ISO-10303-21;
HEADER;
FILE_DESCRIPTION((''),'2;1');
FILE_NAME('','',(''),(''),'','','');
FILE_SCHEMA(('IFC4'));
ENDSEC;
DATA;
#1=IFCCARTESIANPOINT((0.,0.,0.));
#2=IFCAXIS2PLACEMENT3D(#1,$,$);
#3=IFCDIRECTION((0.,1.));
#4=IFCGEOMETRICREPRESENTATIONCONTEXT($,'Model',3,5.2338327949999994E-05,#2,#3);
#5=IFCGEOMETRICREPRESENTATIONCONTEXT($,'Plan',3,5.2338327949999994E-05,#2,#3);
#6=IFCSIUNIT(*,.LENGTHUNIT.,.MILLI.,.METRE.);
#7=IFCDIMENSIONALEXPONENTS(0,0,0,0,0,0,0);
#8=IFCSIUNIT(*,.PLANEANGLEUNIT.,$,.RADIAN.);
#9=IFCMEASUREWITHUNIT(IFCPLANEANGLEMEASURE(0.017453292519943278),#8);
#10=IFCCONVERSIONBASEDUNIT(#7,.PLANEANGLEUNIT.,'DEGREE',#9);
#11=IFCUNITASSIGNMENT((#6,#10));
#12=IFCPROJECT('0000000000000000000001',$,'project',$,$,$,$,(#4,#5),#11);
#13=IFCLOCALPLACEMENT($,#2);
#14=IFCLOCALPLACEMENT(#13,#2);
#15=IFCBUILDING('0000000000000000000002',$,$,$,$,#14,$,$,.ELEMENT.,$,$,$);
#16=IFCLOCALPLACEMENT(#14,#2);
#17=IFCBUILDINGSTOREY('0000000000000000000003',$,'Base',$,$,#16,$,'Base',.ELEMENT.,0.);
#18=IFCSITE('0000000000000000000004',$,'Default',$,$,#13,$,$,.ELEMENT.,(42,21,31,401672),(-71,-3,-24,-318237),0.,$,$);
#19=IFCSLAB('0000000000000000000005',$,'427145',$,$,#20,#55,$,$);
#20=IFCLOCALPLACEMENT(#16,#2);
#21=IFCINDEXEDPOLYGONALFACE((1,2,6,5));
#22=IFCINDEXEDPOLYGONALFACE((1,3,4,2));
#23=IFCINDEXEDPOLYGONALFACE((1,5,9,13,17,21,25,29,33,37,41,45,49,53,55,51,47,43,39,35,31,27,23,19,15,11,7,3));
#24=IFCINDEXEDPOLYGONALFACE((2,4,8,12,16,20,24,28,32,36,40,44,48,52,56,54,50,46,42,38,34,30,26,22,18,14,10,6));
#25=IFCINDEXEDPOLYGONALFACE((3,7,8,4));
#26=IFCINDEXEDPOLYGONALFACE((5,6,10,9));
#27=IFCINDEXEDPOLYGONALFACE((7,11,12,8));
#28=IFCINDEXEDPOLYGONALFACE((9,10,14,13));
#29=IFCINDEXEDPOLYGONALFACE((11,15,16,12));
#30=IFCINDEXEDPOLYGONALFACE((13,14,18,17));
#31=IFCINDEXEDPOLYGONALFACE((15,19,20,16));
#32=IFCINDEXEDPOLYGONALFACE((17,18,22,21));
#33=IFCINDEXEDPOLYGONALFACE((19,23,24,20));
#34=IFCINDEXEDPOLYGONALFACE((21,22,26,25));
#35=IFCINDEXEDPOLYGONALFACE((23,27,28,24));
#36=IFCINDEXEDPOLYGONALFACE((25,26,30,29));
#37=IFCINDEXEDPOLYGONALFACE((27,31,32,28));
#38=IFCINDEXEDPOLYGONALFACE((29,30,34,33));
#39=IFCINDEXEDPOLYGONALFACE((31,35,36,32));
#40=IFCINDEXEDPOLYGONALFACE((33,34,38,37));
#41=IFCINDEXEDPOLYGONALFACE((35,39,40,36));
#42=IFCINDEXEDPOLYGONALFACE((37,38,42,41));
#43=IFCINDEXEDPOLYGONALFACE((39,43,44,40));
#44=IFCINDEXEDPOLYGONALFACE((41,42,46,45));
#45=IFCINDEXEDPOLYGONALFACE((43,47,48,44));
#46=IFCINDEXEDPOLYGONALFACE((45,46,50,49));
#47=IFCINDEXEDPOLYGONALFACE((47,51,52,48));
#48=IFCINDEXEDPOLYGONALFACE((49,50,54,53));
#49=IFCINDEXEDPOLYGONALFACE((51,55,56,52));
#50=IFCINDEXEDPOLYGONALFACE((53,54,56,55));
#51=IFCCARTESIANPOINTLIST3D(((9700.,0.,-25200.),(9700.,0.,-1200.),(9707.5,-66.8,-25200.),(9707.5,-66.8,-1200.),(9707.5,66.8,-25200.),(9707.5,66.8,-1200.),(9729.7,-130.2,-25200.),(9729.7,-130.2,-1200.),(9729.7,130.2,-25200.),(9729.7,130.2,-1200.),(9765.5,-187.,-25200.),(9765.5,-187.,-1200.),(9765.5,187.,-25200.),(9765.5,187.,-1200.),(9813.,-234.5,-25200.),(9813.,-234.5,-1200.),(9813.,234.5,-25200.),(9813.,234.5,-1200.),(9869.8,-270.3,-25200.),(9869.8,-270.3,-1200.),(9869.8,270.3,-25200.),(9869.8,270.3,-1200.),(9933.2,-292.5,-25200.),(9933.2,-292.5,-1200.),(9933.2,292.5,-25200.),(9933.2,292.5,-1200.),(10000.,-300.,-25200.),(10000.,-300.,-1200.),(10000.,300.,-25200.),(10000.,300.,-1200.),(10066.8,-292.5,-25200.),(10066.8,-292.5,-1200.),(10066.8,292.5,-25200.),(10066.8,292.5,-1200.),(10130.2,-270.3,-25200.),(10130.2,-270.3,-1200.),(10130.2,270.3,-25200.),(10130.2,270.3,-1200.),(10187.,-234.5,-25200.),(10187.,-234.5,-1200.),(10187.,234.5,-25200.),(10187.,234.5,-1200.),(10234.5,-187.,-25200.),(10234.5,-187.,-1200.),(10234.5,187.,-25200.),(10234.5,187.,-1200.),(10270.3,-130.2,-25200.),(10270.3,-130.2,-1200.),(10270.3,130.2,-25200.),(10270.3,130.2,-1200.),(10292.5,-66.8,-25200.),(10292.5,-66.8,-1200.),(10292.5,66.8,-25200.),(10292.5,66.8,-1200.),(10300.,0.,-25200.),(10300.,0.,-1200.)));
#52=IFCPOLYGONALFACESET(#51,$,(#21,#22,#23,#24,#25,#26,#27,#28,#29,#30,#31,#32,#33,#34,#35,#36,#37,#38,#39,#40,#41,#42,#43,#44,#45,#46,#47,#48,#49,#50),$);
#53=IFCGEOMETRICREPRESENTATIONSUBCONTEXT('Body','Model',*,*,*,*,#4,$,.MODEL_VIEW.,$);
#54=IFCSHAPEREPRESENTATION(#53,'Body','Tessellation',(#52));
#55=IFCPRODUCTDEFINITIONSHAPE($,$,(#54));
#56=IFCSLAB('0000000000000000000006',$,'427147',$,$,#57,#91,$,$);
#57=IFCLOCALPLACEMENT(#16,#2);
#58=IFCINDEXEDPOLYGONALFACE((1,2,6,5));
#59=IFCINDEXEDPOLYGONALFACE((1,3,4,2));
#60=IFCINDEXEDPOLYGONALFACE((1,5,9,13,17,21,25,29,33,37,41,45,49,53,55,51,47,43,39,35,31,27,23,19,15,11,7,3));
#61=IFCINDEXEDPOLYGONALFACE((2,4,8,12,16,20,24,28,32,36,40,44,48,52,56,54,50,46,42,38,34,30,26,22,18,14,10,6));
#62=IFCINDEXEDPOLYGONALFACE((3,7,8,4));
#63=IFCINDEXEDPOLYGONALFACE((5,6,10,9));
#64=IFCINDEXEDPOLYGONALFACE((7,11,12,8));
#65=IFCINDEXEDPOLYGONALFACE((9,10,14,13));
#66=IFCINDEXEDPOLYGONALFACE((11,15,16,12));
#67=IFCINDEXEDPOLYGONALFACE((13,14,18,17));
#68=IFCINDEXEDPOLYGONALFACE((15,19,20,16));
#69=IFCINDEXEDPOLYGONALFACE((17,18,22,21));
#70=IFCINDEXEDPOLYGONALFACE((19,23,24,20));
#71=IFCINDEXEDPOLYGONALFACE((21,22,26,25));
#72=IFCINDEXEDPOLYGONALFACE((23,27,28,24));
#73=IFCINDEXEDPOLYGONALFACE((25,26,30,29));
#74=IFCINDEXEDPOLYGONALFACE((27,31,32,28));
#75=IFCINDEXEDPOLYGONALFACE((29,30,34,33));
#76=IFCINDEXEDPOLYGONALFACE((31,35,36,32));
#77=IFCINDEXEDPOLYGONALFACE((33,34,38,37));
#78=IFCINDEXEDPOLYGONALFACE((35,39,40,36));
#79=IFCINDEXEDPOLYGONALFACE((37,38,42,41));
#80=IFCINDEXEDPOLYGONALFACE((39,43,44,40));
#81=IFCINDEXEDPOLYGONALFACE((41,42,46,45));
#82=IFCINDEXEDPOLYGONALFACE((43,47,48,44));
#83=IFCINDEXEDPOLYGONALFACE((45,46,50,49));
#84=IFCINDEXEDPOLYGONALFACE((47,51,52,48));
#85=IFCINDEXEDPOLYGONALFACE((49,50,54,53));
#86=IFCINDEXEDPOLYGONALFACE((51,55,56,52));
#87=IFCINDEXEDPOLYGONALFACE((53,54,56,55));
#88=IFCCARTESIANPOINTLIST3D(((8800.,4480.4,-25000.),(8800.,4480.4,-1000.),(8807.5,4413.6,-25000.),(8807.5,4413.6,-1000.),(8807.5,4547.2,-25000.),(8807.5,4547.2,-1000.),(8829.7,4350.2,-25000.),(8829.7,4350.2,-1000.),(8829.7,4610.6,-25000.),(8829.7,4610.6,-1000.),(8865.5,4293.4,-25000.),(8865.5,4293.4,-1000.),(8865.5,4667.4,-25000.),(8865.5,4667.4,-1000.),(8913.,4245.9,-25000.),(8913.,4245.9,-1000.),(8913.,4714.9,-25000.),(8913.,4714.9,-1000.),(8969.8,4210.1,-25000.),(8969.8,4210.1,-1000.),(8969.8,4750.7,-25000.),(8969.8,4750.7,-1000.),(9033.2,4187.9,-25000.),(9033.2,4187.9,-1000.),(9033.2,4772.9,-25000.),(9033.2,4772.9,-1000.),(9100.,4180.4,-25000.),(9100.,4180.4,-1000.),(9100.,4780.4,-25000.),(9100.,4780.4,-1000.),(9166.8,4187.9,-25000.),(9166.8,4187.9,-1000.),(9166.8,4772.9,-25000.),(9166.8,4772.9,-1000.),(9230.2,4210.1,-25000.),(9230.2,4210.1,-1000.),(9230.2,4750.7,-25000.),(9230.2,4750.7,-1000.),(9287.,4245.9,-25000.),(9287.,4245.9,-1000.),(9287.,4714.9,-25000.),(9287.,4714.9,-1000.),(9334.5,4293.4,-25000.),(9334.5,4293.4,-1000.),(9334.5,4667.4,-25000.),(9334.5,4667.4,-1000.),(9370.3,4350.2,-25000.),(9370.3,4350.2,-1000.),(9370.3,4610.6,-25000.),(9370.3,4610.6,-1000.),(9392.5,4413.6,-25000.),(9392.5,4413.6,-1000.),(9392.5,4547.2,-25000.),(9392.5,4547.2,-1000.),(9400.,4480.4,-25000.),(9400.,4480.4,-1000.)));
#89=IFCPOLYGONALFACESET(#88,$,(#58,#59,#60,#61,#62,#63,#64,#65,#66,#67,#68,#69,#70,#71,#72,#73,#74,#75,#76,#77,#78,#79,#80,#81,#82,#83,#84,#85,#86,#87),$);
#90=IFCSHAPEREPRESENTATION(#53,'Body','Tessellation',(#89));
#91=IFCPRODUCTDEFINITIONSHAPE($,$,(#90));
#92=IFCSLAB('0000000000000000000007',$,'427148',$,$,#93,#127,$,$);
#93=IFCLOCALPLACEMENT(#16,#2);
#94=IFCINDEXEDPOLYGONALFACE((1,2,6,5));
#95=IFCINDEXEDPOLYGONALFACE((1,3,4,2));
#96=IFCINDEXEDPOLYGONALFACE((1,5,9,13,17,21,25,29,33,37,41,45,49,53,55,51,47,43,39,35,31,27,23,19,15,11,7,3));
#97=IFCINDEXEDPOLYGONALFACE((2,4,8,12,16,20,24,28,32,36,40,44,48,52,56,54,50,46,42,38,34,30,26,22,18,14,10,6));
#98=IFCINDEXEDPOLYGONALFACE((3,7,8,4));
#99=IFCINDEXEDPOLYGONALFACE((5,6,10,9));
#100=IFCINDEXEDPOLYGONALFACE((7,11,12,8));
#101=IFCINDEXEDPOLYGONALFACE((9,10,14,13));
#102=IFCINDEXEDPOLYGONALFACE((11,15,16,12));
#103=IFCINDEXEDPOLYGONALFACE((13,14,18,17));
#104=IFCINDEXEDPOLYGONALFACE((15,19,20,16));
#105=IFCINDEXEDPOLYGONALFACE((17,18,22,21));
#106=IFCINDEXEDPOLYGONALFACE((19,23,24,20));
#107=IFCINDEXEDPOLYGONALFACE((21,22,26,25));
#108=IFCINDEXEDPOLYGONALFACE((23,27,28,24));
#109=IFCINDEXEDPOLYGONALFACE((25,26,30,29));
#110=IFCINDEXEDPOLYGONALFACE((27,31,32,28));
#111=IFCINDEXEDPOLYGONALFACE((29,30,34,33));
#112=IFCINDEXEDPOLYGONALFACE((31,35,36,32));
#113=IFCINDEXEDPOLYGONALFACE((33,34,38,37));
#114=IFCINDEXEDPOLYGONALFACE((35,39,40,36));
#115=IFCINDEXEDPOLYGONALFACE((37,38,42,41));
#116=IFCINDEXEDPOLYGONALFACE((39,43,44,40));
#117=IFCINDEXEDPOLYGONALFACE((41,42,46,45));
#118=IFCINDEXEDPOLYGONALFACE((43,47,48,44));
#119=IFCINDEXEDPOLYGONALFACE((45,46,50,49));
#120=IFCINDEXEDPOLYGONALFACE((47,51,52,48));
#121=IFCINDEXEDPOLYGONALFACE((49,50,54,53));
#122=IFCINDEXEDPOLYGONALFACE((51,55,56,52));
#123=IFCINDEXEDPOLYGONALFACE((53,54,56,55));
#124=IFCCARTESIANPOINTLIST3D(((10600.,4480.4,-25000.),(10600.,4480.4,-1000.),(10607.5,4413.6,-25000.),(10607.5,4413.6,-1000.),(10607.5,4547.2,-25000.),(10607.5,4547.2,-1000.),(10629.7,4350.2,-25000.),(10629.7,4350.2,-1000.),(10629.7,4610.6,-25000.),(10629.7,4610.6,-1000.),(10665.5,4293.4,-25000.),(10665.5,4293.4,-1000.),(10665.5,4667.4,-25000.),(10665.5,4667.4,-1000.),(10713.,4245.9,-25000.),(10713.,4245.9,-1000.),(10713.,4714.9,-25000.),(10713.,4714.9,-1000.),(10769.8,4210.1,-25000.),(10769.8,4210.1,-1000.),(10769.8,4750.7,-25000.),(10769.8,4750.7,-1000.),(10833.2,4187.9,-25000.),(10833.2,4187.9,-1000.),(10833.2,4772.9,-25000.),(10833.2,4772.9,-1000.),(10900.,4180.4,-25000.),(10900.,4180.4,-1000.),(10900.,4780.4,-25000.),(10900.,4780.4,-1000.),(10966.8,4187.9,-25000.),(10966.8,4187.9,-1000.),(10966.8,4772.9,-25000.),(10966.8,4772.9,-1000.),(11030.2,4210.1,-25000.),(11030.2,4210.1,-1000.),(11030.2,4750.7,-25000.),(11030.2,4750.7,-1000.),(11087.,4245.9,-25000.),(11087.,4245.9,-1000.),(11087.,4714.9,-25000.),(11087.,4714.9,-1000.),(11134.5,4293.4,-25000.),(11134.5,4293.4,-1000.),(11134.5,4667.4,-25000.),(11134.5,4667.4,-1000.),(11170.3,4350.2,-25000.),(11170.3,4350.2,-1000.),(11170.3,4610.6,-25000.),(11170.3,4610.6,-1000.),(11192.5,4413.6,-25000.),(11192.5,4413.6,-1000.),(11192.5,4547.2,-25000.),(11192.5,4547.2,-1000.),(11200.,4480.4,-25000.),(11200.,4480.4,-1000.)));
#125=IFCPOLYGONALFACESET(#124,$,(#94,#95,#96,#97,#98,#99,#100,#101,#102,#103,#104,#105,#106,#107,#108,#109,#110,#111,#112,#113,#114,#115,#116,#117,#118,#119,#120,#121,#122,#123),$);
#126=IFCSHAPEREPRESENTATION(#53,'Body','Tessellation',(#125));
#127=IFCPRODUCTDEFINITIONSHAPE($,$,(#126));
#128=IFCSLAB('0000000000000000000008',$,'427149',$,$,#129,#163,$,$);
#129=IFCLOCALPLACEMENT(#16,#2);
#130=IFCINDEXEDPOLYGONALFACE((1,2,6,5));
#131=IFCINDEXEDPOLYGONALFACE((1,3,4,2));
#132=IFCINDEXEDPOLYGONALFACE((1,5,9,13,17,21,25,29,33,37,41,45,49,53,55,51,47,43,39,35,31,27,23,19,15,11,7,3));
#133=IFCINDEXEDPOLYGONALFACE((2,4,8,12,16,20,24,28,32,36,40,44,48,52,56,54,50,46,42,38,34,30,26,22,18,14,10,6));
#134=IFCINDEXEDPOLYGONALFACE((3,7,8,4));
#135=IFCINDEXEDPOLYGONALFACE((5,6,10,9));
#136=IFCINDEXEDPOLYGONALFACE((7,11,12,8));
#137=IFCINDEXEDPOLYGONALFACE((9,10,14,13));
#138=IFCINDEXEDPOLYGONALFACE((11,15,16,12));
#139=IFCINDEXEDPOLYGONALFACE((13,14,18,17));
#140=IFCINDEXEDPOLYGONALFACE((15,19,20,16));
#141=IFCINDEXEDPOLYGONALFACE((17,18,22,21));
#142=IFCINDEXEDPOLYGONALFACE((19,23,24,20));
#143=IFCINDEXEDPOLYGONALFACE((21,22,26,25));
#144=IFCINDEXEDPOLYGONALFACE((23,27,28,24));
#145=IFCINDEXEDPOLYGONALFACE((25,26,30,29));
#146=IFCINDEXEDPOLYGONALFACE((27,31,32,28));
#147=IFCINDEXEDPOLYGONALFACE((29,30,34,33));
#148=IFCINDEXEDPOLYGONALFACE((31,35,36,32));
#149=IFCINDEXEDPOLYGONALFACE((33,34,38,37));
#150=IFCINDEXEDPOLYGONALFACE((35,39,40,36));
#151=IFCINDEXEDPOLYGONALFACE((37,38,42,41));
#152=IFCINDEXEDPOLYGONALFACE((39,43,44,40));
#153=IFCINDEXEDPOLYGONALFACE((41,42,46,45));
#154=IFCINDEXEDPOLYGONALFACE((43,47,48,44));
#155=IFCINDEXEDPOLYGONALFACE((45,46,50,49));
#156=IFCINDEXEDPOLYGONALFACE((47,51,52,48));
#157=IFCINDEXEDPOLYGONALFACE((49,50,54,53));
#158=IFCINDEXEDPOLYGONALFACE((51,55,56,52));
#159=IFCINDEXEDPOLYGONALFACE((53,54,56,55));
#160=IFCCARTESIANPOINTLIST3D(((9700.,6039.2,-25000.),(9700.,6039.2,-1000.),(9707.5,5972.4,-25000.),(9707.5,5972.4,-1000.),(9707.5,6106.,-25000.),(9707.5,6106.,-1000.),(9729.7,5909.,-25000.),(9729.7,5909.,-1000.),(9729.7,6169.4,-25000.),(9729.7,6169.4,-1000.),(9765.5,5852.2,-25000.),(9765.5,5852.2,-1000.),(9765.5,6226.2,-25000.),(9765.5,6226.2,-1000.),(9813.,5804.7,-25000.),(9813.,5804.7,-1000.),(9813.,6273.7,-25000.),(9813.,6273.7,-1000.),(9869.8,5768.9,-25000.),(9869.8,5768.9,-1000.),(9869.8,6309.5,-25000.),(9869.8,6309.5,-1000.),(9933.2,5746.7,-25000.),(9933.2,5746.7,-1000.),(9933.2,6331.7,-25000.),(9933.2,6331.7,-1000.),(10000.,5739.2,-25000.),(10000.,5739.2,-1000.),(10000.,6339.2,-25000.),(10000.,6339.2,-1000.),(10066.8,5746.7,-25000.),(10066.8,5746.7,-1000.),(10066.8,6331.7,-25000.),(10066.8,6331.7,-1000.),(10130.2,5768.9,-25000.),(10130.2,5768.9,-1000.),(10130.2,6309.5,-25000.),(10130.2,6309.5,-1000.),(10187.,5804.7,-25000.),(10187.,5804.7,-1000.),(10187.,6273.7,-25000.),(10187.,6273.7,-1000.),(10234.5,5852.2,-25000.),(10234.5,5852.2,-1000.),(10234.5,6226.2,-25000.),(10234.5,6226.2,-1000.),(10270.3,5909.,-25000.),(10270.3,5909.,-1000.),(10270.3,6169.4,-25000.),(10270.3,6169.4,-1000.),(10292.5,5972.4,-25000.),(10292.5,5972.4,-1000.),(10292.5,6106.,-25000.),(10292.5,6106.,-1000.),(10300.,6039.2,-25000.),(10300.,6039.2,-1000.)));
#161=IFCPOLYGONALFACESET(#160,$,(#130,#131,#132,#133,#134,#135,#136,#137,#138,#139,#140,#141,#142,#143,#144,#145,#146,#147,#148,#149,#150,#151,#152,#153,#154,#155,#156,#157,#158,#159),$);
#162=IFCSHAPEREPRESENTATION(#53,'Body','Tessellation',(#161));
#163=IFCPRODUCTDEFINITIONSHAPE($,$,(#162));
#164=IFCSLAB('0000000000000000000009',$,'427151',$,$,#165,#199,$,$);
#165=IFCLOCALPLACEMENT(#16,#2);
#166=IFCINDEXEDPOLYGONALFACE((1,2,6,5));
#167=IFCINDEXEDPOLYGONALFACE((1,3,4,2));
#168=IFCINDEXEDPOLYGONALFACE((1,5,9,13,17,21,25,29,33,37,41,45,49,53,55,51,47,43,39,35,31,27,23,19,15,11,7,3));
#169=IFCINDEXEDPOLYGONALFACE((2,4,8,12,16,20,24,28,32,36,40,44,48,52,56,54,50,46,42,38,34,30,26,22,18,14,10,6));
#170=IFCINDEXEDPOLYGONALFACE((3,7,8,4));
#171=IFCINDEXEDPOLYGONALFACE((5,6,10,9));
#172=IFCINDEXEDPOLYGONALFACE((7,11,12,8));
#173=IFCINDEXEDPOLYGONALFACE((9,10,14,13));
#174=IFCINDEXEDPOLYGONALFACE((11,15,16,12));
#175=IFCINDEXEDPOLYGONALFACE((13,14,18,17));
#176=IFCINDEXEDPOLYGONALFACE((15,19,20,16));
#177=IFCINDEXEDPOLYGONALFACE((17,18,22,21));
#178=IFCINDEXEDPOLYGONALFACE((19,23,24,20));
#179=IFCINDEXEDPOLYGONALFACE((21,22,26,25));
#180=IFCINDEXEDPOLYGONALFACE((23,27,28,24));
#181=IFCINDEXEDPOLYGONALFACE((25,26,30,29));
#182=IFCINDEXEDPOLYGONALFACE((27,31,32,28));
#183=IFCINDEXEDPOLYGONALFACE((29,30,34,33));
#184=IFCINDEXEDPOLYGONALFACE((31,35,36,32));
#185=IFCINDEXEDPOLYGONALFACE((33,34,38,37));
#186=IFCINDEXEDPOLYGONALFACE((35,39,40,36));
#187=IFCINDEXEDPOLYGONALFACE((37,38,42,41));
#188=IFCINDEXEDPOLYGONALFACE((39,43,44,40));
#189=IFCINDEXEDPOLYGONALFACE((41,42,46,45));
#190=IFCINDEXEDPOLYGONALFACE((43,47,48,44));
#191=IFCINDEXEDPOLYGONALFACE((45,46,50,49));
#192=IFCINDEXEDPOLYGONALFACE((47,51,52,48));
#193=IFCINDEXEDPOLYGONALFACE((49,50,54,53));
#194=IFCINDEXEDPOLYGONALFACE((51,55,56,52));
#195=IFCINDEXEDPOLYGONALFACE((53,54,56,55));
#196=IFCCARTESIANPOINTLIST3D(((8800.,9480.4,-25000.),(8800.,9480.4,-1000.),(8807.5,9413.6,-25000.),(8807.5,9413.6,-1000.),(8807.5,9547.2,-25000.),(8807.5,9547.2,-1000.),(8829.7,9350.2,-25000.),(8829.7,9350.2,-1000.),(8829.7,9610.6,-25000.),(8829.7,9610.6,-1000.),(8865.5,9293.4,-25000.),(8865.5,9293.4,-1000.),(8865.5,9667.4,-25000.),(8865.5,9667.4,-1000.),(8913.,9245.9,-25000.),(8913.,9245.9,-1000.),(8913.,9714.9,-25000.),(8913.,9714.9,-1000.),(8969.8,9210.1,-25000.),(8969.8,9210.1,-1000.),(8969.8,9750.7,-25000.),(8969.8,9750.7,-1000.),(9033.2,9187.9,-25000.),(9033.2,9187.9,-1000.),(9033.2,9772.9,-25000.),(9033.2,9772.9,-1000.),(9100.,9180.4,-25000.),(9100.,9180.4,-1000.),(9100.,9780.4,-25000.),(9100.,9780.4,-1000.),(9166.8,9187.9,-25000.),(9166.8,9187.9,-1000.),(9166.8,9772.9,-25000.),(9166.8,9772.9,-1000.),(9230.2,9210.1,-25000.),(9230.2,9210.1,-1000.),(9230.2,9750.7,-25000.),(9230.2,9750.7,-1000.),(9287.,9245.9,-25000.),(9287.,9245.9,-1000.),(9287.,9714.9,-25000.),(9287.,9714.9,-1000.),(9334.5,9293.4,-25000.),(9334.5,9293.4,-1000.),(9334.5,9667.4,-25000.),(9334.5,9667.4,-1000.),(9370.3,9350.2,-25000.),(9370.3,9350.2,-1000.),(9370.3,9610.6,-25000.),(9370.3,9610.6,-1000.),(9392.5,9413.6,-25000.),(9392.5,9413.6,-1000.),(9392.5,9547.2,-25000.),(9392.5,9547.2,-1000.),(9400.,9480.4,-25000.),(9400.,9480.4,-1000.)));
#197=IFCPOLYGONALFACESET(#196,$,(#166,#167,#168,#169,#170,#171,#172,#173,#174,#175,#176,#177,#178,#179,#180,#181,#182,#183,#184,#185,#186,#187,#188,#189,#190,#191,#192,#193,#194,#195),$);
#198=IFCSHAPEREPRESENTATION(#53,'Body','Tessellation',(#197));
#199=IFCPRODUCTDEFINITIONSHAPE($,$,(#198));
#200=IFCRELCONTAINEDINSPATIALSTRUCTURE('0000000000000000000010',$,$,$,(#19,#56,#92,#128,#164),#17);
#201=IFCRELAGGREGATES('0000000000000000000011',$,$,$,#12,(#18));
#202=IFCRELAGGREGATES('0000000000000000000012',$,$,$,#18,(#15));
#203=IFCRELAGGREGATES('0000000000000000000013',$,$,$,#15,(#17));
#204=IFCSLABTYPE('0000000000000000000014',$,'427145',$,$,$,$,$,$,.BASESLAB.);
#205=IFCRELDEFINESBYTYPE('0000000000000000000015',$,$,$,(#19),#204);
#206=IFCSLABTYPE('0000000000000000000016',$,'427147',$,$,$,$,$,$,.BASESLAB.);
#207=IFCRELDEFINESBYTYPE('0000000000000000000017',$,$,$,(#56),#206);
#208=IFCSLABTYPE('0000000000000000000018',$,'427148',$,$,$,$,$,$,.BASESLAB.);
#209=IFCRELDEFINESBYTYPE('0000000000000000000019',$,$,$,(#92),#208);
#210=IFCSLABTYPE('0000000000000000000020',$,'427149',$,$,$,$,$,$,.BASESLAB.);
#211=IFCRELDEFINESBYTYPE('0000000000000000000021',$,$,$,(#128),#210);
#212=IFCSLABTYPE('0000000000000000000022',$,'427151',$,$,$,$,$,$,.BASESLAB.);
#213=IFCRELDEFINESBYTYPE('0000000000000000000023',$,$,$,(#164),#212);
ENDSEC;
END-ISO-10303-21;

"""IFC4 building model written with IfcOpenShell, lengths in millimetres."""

from ifc_helpers import new_model, entity, si_unit, converted_unit, direction, frame, origin, place, context, subcontext, project, spatial, arc, indexed_curve, outline, extrude, type_object, element, save


model = new_model("IFC4")

# Units and contexts
model_context = context("Model", 3, precision=5.2338327949999994e-05, world=origin(), true_north=direction((0.0, 1.0)))
plan_context = context("Plan", 3, precision=5.2338327949999994e-05, world=origin(), true_north=direction((0.0, 1.0)))
body_context = subcontext(model_context, "Body", "Model", "MODEL_VIEW")
ifc_project = project(units=[si_unit("LENGTHUNIT", "METRE", prefix="MILLI"), converted_unit("PLANEANGLEUNIT", "DEGREE", entity("IfcPlaneAngleMeasure", 0.017453292519943278), si_unit("PLANEANGLEUNIT", "RADIAN"), dimensions=[0, 0, 0, 0, 0, 0, 0])], contexts=[model_context, plan_context])

# Site, building, storey
site_placement = place(None, origin())
site = spatial("IfcSite", under=ifc_project, at=site_placement, Name="Default", CompositionType="ELEMENT", RefLatitude=(42, 21, 31, 401672), RefLongitude=(-71, -3, -24, -318237), RefElevation=0.0)
building_placement = place(site_placement, origin())
building = spatial("IfcBuilding", under=site, at=building_placement, CompositionType="ELEMENT")
storey_placement = place(building_placement, origin())
storey = spatial("IfcBuildingStorey", under=building, at=storey_placement, Name="Base", LongName="Base", CompositionType="ELEMENT", Elevation=0.0)

# Slabs
slab_type_1 = type_object("IfcSlabType", Name="427145", PredefinedType="BASESLAB")
slab_1_placement = place(storey_placement, origin())
element("IfcSlab", 1, at=slab_1_placement, inside=storey, type_object=slab_type_1, Name="427145", context=body_context, shape_type="SweptSolid", body=[
    extrude(outline(indexed_curve([(300.0, 0.0), (0.0, 300.0), (-300.0, 0.0), (0.0, -300.0)], segments=[arc(1, 2, 3), arc(3, 4, 1)], self_intersect=False)), frame((10000.0, 0.0, -25200.0)), (0.0, 0.0, 1.0), 24000.0),
])
slab_type_2 = type_object("IfcSlabType", Name="427147", PredefinedType="BASESLAB")
slab_2_placement = place(storey_placement, origin())
element("IfcSlab", 2, at=slab_2_placement, inside=storey, type_object=slab_type_2, Name="427147", context=body_context, shape_type="SweptSolid", body=[
    extrude(outline(indexed_curve([(300.0, 0.0), (0.0, 300.0), (-300.0, 0.0), (0.0, -300.0)], segments=[arc(1, 2, 3), arc(3, 4, 1)], self_intersect=False)), frame((9100.0, 4480.4, -25000.0)), (0.0, 0.0, 1.0), 24000.0),
])
slab_type_3 = type_object("IfcSlabType", Name="427148", PredefinedType="BASESLAB")
slab_3_placement = place(storey_placement, origin())
element("IfcSlab", 3, at=slab_3_placement, inside=storey, type_object=slab_type_3, Name="427148", context=body_context, shape_type="SweptSolid", body=[
    extrude(outline(indexed_curve([(300.0, 0.0), (0.0, 300.0), (-300.0, 0.0), (0.0, -300.0)], segments=[arc(1, 2, 3), arc(3, 4, 1)], self_intersect=False)), frame((10900.0, 4480.4, -25000.0)), (0.0, 0.0, 1.0), 24000.0),
])
slab_type_4 = type_object("IfcSlabType", Name="427149", PredefinedType="BASESLAB")
slab_4_placement = place(storey_placement, origin())
element("IfcSlab", 4, at=slab_4_placement, inside=storey, type_object=slab_type_4, Name="427149", context=body_context, shape_type="SweptSolid", body=[
    extrude(outline(indexed_curve([(300.0, 0.0), (0.0, 300.0), (-300.0, 0.0), (0.0, -300.0)], segments=[arc(1, 2, 3), arc(3, 4, 1)], self_intersect=False)), frame((10000.0, 6039.2, -25000.0)), (0.0, 0.0, 1.0), 24000.0),
])
slab_type_5 = type_object("IfcSlabType", Name="427151", PredefinedType="BASESLAB")
slab_5_placement = place(storey_placement, origin())
element("IfcSlab", 5, at=slab_5_placement, inside=storey, type_object=slab_type_5, Name="427151", context=body_context, shape_type="SweptSolid", body=[
    extrude(outline(indexed_curve([(300.0, 0.0), (0.0, 300.0), (-300.0, 0.0), (0.0, -300.0)], segments=[arc(1, 2, 3), arc(3, 4, 1)], self_intersect=False)), frame((9100.0, 9480.4, -25000.0)), (0.0, 0.0, 1.0), 24000.0),
])

save(model, "model.ifc")
